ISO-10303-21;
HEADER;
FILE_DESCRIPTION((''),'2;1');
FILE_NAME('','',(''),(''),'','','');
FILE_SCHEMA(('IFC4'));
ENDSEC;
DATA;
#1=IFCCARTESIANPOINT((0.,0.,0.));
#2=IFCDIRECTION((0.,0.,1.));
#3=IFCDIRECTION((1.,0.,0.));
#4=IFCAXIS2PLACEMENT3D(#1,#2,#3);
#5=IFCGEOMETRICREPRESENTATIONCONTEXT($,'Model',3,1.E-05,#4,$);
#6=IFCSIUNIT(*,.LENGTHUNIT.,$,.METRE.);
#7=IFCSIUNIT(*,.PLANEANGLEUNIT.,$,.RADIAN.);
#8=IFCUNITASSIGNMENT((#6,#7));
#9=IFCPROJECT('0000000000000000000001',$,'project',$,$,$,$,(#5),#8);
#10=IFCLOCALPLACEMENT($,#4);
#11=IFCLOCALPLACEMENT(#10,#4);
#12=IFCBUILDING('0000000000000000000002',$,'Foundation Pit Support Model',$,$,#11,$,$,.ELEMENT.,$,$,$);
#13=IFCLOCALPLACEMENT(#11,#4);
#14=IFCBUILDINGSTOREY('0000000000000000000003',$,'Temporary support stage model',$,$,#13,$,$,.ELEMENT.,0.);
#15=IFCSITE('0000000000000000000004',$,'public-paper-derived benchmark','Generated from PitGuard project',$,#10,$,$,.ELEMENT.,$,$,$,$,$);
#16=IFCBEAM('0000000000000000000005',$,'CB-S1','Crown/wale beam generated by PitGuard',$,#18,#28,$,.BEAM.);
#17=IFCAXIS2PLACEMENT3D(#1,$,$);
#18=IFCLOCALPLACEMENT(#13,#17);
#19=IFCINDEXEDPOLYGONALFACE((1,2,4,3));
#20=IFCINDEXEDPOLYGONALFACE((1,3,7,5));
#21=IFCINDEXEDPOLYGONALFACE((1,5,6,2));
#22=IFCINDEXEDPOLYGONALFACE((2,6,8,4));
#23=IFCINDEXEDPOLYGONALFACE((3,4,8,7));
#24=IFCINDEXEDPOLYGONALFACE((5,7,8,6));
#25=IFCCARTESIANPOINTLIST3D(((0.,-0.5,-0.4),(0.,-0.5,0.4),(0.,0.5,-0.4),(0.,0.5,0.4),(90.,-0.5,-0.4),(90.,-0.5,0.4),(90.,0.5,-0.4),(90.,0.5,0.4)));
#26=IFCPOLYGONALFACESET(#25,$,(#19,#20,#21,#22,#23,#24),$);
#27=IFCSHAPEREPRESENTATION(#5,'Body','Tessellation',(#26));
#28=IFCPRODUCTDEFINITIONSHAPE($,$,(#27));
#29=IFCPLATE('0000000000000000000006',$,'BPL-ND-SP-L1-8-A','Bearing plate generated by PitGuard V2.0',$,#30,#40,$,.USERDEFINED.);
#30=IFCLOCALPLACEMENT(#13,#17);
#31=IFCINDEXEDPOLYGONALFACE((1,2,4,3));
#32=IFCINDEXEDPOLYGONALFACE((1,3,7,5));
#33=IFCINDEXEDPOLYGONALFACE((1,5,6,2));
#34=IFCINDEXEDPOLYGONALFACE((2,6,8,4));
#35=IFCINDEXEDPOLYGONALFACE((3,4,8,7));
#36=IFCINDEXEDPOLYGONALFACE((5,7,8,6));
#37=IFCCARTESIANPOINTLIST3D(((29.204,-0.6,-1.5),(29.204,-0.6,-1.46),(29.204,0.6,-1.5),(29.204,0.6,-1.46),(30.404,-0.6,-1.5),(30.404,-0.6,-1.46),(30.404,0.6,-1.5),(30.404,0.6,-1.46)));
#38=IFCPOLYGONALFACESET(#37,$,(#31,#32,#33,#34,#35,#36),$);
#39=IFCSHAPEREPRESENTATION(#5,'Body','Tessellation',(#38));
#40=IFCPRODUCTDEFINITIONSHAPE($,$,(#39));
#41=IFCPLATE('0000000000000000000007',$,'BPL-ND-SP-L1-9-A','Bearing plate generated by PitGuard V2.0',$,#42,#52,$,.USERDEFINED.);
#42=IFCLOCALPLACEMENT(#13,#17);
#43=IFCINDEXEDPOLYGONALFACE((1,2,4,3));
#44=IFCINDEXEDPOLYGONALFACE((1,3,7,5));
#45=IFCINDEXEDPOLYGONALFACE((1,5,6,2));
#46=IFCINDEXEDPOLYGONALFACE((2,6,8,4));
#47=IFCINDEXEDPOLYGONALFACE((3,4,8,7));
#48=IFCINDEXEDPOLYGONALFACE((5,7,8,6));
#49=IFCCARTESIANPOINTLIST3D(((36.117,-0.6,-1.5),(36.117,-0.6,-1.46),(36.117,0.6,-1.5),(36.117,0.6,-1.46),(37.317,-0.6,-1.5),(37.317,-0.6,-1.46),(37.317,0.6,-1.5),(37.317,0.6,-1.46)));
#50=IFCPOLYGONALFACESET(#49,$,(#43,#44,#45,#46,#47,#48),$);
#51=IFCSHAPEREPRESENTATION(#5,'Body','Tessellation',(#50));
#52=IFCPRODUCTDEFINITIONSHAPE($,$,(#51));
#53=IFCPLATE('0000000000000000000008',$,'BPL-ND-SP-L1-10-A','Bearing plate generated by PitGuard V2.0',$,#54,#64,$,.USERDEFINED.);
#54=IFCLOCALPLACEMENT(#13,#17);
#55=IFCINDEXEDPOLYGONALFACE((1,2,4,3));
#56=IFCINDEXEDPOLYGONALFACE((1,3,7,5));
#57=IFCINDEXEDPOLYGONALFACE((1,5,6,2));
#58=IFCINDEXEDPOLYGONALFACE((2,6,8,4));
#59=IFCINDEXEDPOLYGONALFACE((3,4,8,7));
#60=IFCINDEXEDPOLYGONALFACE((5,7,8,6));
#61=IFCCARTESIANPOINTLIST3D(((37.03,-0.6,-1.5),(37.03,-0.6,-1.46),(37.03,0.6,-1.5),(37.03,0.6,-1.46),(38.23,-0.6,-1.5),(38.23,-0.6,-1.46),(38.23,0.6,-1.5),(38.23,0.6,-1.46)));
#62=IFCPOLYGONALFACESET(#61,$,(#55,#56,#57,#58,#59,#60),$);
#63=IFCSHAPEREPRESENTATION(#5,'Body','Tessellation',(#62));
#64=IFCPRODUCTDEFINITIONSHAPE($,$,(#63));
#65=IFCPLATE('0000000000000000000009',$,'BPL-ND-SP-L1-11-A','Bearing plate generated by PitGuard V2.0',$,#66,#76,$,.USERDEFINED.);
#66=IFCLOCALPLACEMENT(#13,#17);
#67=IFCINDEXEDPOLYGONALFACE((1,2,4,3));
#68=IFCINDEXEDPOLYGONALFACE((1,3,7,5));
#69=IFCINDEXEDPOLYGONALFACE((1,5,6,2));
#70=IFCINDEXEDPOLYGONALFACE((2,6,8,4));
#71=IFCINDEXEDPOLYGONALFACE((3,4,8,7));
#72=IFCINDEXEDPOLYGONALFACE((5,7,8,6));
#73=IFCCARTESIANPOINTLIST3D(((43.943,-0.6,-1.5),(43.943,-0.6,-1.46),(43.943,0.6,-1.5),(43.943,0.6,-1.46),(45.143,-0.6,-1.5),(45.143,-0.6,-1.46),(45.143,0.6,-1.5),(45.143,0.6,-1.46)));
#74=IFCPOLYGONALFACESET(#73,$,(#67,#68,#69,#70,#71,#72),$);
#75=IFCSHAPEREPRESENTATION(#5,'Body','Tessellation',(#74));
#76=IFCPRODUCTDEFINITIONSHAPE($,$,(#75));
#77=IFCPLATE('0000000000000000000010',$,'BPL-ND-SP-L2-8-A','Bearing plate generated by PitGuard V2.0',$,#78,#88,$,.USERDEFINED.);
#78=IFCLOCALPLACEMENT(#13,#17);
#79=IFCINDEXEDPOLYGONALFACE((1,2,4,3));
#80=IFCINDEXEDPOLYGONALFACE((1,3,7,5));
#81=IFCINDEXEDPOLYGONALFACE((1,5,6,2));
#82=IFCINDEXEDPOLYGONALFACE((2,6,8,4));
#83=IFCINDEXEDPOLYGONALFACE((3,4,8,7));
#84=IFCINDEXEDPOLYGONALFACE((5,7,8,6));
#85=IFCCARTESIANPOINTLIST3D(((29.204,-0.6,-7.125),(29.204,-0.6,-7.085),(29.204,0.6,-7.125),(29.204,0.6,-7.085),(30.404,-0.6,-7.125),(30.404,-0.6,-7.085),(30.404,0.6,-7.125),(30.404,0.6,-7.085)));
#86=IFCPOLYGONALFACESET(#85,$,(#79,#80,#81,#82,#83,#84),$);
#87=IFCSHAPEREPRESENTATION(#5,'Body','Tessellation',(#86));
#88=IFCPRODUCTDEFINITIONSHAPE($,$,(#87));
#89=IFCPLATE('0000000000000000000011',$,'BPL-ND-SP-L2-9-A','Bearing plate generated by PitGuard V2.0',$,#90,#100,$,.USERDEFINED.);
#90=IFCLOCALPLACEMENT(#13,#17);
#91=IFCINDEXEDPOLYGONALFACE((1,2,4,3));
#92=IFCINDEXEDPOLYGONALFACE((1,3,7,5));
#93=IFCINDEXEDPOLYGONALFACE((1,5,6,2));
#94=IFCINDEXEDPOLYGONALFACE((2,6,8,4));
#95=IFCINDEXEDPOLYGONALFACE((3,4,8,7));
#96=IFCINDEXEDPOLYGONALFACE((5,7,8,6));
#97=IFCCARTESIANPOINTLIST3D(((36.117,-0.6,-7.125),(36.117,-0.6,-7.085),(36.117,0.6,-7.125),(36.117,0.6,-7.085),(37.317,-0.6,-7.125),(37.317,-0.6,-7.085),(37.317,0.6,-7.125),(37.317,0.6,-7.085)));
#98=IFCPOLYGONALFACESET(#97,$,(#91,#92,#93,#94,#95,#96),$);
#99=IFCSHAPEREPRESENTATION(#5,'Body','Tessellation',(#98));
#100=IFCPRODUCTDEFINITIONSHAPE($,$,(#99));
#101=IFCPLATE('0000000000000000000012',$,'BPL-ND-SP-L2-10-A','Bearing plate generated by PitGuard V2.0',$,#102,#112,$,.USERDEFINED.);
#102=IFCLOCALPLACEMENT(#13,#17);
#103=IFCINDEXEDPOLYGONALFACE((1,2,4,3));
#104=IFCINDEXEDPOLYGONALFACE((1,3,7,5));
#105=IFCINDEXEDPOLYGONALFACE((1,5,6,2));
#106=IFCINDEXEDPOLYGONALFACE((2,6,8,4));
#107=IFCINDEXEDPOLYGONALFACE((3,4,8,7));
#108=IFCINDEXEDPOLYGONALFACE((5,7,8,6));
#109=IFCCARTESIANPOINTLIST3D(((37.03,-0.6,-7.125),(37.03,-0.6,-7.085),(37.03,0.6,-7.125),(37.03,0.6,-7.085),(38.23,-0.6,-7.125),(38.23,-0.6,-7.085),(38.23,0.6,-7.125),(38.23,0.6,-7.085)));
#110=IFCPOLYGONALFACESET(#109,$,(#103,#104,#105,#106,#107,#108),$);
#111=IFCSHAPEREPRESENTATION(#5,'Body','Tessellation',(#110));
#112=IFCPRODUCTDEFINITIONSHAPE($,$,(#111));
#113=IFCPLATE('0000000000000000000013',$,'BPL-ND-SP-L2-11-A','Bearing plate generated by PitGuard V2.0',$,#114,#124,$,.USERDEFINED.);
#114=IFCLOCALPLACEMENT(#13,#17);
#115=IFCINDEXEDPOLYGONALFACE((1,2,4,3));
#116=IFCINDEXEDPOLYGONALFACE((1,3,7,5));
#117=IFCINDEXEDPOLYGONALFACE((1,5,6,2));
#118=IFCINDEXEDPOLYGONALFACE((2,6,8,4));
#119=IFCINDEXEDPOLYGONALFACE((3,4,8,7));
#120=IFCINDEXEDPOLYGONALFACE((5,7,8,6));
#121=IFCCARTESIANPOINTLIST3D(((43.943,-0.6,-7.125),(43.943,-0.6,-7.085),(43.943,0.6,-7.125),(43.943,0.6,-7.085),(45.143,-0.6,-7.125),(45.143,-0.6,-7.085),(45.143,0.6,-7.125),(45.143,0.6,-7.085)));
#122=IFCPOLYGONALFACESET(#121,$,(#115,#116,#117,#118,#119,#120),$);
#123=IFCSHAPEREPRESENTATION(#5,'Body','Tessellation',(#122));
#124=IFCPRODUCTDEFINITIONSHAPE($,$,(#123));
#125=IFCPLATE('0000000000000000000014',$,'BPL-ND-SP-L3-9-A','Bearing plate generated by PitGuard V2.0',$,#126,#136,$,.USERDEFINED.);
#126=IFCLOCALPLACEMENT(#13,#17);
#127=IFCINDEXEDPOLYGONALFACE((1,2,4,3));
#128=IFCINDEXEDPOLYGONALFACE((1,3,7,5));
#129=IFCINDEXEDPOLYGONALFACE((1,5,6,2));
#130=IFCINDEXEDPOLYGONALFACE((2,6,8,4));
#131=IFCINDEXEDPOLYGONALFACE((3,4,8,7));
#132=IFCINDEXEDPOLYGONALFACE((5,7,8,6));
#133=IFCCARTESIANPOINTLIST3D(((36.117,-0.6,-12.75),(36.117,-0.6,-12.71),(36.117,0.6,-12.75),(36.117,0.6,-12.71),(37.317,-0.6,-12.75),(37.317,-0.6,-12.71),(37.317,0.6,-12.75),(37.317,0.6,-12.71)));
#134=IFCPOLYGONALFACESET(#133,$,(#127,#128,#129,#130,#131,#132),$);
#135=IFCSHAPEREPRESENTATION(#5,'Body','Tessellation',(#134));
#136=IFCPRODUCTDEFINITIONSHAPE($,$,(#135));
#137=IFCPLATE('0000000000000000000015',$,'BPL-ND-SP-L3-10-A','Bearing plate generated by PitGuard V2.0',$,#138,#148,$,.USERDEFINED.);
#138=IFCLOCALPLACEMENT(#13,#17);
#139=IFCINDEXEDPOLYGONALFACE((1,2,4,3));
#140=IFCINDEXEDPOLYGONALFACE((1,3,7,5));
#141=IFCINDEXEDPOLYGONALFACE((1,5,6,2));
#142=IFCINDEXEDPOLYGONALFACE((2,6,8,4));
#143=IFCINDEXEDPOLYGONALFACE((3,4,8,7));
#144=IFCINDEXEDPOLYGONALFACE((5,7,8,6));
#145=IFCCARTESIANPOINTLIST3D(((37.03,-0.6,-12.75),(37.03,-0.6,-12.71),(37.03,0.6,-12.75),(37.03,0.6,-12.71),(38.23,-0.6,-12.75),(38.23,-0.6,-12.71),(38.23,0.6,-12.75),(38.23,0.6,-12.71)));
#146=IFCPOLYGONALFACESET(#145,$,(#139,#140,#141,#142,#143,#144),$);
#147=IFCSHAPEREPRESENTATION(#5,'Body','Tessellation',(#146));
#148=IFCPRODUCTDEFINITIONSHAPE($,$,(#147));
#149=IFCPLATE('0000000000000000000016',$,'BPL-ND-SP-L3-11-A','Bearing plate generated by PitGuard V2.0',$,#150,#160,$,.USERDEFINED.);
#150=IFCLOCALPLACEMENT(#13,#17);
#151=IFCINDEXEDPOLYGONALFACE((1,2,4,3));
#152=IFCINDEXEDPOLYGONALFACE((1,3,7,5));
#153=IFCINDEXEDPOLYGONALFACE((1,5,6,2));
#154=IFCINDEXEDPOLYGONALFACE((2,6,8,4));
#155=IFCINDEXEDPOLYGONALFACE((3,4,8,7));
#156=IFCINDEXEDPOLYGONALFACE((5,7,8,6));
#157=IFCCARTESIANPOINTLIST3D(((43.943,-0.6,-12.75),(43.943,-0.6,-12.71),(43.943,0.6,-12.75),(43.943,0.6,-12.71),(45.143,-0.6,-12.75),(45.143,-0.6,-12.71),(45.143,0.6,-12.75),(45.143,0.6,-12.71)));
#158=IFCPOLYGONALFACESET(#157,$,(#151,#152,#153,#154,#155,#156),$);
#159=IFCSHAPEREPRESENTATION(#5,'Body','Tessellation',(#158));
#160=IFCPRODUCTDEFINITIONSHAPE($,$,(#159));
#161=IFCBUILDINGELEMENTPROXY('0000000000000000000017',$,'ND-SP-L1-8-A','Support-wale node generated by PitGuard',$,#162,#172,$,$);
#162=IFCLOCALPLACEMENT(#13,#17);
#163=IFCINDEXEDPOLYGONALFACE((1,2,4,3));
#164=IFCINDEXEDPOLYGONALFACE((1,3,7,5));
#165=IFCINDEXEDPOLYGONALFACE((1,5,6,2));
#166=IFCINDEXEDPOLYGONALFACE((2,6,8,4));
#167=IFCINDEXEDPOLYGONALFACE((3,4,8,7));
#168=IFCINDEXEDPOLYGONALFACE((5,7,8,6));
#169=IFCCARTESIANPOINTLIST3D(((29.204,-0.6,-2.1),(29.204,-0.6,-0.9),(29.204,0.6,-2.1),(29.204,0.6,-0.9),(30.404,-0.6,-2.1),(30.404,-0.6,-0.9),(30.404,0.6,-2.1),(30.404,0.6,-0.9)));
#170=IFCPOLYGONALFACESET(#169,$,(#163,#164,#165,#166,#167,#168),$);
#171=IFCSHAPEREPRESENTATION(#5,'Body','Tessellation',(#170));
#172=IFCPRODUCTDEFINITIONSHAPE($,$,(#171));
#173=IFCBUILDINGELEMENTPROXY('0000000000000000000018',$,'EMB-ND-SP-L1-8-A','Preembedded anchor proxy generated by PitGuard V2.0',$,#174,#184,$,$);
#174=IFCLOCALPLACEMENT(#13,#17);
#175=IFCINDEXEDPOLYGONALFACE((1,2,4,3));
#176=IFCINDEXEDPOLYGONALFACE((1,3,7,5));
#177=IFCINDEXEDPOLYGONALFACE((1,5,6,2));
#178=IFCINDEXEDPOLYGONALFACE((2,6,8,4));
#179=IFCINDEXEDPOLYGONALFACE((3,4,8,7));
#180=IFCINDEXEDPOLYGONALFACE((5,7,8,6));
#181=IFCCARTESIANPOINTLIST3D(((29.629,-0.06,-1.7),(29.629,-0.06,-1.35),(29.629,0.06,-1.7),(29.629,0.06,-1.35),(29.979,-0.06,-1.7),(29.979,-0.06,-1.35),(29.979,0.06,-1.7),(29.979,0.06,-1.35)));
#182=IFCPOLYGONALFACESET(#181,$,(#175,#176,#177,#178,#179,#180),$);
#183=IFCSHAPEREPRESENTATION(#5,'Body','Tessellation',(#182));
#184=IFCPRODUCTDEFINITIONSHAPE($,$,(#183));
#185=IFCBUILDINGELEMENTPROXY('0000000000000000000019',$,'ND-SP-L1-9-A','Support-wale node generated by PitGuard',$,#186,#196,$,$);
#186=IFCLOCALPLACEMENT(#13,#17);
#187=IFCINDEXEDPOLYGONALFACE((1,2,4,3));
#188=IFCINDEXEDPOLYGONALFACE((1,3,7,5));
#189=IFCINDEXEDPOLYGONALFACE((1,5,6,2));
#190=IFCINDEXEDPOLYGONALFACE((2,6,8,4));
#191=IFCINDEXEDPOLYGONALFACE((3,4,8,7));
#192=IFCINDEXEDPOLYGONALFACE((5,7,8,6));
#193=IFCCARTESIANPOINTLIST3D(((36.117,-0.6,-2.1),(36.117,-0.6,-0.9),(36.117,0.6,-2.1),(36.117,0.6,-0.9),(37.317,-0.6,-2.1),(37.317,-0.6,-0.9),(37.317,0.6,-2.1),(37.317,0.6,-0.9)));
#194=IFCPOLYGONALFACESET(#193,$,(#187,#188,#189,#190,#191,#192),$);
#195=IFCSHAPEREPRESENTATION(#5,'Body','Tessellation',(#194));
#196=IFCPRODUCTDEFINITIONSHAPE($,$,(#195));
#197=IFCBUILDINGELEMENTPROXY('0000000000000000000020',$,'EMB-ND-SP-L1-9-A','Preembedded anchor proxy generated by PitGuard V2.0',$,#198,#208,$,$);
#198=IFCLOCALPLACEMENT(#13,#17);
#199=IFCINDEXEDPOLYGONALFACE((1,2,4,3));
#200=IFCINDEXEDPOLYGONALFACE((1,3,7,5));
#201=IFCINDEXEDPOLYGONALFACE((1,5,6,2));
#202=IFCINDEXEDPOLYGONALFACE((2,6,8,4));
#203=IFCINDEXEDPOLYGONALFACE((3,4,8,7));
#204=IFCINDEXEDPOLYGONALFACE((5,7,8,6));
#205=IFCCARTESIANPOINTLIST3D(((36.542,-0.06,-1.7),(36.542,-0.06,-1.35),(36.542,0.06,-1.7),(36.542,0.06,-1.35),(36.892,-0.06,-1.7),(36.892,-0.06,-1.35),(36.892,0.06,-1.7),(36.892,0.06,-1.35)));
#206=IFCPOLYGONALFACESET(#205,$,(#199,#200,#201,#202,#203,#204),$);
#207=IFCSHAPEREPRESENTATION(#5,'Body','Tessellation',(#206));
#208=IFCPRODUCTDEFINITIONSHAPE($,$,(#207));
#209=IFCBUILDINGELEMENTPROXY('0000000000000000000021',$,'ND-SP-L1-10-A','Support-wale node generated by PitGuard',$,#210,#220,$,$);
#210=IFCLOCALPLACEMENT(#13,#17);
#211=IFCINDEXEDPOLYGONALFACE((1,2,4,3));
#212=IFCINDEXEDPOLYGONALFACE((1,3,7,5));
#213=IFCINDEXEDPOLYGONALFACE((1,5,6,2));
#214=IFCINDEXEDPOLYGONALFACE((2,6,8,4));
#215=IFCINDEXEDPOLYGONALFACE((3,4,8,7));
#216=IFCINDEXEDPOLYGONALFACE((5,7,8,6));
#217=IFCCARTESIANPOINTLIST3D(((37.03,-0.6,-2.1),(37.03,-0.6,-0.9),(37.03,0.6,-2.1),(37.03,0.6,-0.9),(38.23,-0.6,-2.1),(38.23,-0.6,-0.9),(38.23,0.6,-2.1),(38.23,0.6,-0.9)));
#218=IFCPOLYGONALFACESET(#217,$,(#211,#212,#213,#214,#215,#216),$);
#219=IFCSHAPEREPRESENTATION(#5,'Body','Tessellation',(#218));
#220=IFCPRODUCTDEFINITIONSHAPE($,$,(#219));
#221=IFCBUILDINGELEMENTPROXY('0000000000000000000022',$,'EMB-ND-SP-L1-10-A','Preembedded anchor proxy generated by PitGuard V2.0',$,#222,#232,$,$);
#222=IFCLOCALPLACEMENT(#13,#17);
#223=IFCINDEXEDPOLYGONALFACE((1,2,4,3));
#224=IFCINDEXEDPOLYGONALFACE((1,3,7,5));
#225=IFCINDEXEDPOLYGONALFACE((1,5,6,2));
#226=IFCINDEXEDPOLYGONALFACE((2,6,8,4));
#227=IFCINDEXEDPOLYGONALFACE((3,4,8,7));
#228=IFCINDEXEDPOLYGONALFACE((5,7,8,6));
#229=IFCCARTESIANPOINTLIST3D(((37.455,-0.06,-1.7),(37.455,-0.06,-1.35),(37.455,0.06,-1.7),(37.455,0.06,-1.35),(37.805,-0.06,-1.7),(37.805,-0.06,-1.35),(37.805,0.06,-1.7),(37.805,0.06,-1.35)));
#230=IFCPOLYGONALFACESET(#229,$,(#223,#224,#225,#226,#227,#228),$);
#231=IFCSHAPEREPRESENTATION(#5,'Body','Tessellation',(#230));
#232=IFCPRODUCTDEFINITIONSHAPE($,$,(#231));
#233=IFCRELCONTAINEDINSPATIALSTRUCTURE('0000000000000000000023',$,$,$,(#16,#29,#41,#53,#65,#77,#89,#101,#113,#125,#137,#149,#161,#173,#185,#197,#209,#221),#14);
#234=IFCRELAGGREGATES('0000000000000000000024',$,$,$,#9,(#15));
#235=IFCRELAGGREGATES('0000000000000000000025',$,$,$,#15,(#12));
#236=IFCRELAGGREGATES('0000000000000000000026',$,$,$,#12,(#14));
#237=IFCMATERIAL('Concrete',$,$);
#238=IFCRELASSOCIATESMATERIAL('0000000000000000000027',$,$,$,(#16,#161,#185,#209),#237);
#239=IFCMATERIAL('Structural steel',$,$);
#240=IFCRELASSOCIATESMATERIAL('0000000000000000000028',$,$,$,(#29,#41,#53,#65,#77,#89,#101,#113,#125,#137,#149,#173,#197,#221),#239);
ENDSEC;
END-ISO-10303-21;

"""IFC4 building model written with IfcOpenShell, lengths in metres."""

from ifc_helpers import new_model, si_unit, frame, origin_with_axes, origin_2d, place, context, project, spatial, rectangle, extrude, material, element, save


model = new_model("IFC4")

# Units and contexts
model_context = context("Model", 3, precision=1e-05, world=origin_with_axes())
ifc_project = project(units=[si_unit("LENGTHUNIT", "METRE"), si_unit("PLANEANGLEUNIT", "RADIAN")], contexts=[model_context])

# Site, building, storey
site_placement = place(None, origin_with_axes())
site = spatial("IfcSite", under=ifc_project, at=site_placement, Name="public-paper-derived benchmark", Description="Generated from PitGuard project", CompositionType="ELEMENT")
building_placement = place(site_placement, origin_with_axes())
building = spatial("IfcBuilding", under=site, at=building_placement, Name="Foundation Pit Support Model", CompositionType="ELEMENT")
storey_placement = place(building_placement, origin_with_axes())
storey = spatial("IfcBuildingStorey", under=building, at=storey_placement, Name="Temporary support stage model", CompositionType="ELEMENT", Elevation=0.0)

# Beam
ifc_material_1 = material(Name="Concrete")
beam_placement = place(storey_placement, frame((45.0, 0.0, -0.4), z_axis=(0.0, 0.0, 1.0), x_axis=(1.0, 0.0, 0.0)))
element("IfcBeam", 1, at=beam_placement, inside=storey, material=ifc_material_1, Name="CB-S1", Description="Crown/wale beam generated by PitGuard", PredefinedType="BEAM", context=model_context, shape_type="SweptSolid", body=[
    extrude(rectangle(XDim=90.0, YDim=1.0, at=origin_2d()), origin_with_axes(), (0.0, 0.0, 1.0), 0.8),
])

# Plates
ifc_material_2 = material(Name="Structural steel")
for number, where, z_axis, x_axis, name in (
    (2, (29.804, 0.0, -1.5), (0.0, 0.0, 1.0), (1.0, 0.0, 0.0), "BPL-ND-SP-L1-8-A"),
    (3, (36.717, 0.0, -1.5), (0.0, 0.0, 1.0), (1.0, 0.0, 0.0), "BPL-ND-SP-L1-9-A"),
    (4, (37.63, 0.0, -1.5), (0.0, 0.0, 1.0), (1.0, 0.0, 0.0), "BPL-ND-SP-L1-10-A"),
    (5, (44.543, 0.0, -1.5), (0.0, 0.0, 1.0), (1.0, 0.0, 0.0), "BPL-ND-SP-L1-11-A"),
    (6, (29.804, 0.0, -7.125), (0.0, 0.0, 1.0), (1.0, 0.0, 0.0), "BPL-ND-SP-L2-8-A"),
    (7, (36.717, 0.0, -7.125), (0.0, 0.0, 1.0), (1.0, 0.0, 0.0), "BPL-ND-SP-L2-9-A"),
    (8, (37.63, 0.0, -7.125), (0.0, 0.0, 1.0), (1.0, 0.0, 0.0), "BPL-ND-SP-L2-10-A"),
    (9, (44.543, 0.0, -7.125), (0.0, 0.0, 1.0), (1.0, 0.0, 0.0), "BPL-ND-SP-L2-11-A"),
    (10, (36.717, 0.0, -12.75), (0.0, 0.0, 1.0), (1.0, 0.0, 0.0), "BPL-ND-SP-L3-9-A"),
    (11, (37.63, 0.0, -12.75), (0.0, 0.0, 1.0), (1.0, 0.0, 0.0), "BPL-ND-SP-L3-10-A"),
    (12, (44.543, 0.0, -12.75), (0.0, 0.0, 1.0), (1.0, 0.0, 0.0), "BPL-ND-SP-L3-11-A"),
):
    element("IfcPlate", number, at=place(storey_placement, frame(where, z_axis=z_axis, x_axis=x_axis)), inside=storey, material=ifc_material_2, Name=name, Description="Bearing plate generated by PitGuard V2.0", PredefinedType="USERDEFINED", context=model_context, shape_type="SweptSolid", body=[
        extrude(rectangle(XDim=1.2, YDim=1.2, at=origin_2d()), origin_with_axes(), (0.0, 0.0, 1.0), 0.04),
    ])

# Building element proxies
proxy_1_placement = place(storey_placement, frame((29.804, 0.0, -2.1), z_axis=(0.0, 0.0, 1.0), x_axis=(1.0, 0.0, 0.0)))
element("IfcBuildingElementProxy", 13, at=proxy_1_placement, inside=storey, material=ifc_material_1, Name="ND-SP-L1-8-A", Description="Support-wale node generated by PitGuard", context=model_context, shape_type="SweptSolid", body=[
    extrude(rectangle(XDim=1.2, YDim=1.2, at=origin_2d()), origin_with_axes(), (0.0, 0.0, 1.0), 1.2),
])
proxy_2_placement = place(storey_placement, frame((29.804, 0.0, -1.7), z_axis=(0.0, 0.0, 1.0), x_axis=(1.0, 0.0, 0.0)))
element("IfcBuildingElementProxy", 14, at=proxy_2_placement, inside=storey, material=ifc_material_2, Name="EMB-ND-SP-L1-8-A", Description="Preembedded anchor proxy generated by PitGuard V2.0", context=model_context, shape_type="SweptSolid", body=[
    extrude(rectangle(XDim=0.35, YDim=0.12, at=origin_2d()), origin_with_axes(), (0.0, 0.0, 1.0), 0.35),
])
proxy_3_placement = place(storey_placement, frame((36.717, 0.0, -2.1), z_axis=(0.0, 0.0, 1.0), x_axis=(1.0, 0.0, 0.0)))
element("IfcBuildingElementProxy", 15, at=proxy_3_placement, inside=storey, material=ifc_material_1, Name="ND-SP-L1-9-A", Description="Support-wale node generated by PitGuard", context=model_context, shape_type="SweptSolid", body=[
    extrude(rectangle(XDim=1.2, YDim=1.2, at=origin_2d()), origin_with_axes(), (0.0, 0.0, 1.0), 1.2),
])
proxy_4_placement = place(storey_placement, frame((36.717, 0.0, -1.7), z_axis=(0.0, 0.0, 1.0), x_axis=(1.0, 0.0, 0.0)))
element("IfcBuildingElementProxy", 16, at=proxy_4_placement, inside=storey, material=ifc_material_2, Name="EMB-ND-SP-L1-9-A", Description="Preembedded anchor proxy generated by PitGuard V2.0", context=model_context, shape_type="SweptSolid", body=[
    extrude(rectangle(XDim=0.35, YDim=0.12, at=origin_2d()), origin_with_axes(), (0.0, 0.0, 1.0), 0.35),
])
proxy_5_placement = place(storey_placement, frame((37.63, 0.0, -2.1), z_axis=(0.0, 0.0, 1.0), x_axis=(1.0, 0.0, 0.0)))
element("IfcBuildingElementProxy", 17, at=proxy_5_placement, inside=storey, material=ifc_material_1, Name="ND-SP-L1-10-A", Description="Support-wale node generated by PitGuard", context=model_context, shape_type="SweptSolid", body=[
    extrude(rectangle(XDim=1.2, YDim=1.2, at=origin_2d()), origin_with_axes(), (0.0, 0.0, 1.0), 1.2),
])
proxy_6_placement = place(storey_placement, frame((37.63, 0.0, -1.7), z_axis=(0.0, 0.0, 1.0), x_axis=(1.0, 0.0, 0.0)))
element("IfcBuildingElementProxy", 18, at=proxy_6_placement, inside=storey, material=ifc_material_2, Name="EMB-ND-SP-L1-10-A", Description="Preembedded anchor proxy generated by PitGuard V2.0", context=model_context, shape_type="SweptSolid", body=[
    extrude(rectangle(XDim=0.35, YDim=0.12, at=origin_2d()), origin_with_axes(), (0.0, 0.0, 1.0), 0.35),
])

save(model, "model.ifc")
